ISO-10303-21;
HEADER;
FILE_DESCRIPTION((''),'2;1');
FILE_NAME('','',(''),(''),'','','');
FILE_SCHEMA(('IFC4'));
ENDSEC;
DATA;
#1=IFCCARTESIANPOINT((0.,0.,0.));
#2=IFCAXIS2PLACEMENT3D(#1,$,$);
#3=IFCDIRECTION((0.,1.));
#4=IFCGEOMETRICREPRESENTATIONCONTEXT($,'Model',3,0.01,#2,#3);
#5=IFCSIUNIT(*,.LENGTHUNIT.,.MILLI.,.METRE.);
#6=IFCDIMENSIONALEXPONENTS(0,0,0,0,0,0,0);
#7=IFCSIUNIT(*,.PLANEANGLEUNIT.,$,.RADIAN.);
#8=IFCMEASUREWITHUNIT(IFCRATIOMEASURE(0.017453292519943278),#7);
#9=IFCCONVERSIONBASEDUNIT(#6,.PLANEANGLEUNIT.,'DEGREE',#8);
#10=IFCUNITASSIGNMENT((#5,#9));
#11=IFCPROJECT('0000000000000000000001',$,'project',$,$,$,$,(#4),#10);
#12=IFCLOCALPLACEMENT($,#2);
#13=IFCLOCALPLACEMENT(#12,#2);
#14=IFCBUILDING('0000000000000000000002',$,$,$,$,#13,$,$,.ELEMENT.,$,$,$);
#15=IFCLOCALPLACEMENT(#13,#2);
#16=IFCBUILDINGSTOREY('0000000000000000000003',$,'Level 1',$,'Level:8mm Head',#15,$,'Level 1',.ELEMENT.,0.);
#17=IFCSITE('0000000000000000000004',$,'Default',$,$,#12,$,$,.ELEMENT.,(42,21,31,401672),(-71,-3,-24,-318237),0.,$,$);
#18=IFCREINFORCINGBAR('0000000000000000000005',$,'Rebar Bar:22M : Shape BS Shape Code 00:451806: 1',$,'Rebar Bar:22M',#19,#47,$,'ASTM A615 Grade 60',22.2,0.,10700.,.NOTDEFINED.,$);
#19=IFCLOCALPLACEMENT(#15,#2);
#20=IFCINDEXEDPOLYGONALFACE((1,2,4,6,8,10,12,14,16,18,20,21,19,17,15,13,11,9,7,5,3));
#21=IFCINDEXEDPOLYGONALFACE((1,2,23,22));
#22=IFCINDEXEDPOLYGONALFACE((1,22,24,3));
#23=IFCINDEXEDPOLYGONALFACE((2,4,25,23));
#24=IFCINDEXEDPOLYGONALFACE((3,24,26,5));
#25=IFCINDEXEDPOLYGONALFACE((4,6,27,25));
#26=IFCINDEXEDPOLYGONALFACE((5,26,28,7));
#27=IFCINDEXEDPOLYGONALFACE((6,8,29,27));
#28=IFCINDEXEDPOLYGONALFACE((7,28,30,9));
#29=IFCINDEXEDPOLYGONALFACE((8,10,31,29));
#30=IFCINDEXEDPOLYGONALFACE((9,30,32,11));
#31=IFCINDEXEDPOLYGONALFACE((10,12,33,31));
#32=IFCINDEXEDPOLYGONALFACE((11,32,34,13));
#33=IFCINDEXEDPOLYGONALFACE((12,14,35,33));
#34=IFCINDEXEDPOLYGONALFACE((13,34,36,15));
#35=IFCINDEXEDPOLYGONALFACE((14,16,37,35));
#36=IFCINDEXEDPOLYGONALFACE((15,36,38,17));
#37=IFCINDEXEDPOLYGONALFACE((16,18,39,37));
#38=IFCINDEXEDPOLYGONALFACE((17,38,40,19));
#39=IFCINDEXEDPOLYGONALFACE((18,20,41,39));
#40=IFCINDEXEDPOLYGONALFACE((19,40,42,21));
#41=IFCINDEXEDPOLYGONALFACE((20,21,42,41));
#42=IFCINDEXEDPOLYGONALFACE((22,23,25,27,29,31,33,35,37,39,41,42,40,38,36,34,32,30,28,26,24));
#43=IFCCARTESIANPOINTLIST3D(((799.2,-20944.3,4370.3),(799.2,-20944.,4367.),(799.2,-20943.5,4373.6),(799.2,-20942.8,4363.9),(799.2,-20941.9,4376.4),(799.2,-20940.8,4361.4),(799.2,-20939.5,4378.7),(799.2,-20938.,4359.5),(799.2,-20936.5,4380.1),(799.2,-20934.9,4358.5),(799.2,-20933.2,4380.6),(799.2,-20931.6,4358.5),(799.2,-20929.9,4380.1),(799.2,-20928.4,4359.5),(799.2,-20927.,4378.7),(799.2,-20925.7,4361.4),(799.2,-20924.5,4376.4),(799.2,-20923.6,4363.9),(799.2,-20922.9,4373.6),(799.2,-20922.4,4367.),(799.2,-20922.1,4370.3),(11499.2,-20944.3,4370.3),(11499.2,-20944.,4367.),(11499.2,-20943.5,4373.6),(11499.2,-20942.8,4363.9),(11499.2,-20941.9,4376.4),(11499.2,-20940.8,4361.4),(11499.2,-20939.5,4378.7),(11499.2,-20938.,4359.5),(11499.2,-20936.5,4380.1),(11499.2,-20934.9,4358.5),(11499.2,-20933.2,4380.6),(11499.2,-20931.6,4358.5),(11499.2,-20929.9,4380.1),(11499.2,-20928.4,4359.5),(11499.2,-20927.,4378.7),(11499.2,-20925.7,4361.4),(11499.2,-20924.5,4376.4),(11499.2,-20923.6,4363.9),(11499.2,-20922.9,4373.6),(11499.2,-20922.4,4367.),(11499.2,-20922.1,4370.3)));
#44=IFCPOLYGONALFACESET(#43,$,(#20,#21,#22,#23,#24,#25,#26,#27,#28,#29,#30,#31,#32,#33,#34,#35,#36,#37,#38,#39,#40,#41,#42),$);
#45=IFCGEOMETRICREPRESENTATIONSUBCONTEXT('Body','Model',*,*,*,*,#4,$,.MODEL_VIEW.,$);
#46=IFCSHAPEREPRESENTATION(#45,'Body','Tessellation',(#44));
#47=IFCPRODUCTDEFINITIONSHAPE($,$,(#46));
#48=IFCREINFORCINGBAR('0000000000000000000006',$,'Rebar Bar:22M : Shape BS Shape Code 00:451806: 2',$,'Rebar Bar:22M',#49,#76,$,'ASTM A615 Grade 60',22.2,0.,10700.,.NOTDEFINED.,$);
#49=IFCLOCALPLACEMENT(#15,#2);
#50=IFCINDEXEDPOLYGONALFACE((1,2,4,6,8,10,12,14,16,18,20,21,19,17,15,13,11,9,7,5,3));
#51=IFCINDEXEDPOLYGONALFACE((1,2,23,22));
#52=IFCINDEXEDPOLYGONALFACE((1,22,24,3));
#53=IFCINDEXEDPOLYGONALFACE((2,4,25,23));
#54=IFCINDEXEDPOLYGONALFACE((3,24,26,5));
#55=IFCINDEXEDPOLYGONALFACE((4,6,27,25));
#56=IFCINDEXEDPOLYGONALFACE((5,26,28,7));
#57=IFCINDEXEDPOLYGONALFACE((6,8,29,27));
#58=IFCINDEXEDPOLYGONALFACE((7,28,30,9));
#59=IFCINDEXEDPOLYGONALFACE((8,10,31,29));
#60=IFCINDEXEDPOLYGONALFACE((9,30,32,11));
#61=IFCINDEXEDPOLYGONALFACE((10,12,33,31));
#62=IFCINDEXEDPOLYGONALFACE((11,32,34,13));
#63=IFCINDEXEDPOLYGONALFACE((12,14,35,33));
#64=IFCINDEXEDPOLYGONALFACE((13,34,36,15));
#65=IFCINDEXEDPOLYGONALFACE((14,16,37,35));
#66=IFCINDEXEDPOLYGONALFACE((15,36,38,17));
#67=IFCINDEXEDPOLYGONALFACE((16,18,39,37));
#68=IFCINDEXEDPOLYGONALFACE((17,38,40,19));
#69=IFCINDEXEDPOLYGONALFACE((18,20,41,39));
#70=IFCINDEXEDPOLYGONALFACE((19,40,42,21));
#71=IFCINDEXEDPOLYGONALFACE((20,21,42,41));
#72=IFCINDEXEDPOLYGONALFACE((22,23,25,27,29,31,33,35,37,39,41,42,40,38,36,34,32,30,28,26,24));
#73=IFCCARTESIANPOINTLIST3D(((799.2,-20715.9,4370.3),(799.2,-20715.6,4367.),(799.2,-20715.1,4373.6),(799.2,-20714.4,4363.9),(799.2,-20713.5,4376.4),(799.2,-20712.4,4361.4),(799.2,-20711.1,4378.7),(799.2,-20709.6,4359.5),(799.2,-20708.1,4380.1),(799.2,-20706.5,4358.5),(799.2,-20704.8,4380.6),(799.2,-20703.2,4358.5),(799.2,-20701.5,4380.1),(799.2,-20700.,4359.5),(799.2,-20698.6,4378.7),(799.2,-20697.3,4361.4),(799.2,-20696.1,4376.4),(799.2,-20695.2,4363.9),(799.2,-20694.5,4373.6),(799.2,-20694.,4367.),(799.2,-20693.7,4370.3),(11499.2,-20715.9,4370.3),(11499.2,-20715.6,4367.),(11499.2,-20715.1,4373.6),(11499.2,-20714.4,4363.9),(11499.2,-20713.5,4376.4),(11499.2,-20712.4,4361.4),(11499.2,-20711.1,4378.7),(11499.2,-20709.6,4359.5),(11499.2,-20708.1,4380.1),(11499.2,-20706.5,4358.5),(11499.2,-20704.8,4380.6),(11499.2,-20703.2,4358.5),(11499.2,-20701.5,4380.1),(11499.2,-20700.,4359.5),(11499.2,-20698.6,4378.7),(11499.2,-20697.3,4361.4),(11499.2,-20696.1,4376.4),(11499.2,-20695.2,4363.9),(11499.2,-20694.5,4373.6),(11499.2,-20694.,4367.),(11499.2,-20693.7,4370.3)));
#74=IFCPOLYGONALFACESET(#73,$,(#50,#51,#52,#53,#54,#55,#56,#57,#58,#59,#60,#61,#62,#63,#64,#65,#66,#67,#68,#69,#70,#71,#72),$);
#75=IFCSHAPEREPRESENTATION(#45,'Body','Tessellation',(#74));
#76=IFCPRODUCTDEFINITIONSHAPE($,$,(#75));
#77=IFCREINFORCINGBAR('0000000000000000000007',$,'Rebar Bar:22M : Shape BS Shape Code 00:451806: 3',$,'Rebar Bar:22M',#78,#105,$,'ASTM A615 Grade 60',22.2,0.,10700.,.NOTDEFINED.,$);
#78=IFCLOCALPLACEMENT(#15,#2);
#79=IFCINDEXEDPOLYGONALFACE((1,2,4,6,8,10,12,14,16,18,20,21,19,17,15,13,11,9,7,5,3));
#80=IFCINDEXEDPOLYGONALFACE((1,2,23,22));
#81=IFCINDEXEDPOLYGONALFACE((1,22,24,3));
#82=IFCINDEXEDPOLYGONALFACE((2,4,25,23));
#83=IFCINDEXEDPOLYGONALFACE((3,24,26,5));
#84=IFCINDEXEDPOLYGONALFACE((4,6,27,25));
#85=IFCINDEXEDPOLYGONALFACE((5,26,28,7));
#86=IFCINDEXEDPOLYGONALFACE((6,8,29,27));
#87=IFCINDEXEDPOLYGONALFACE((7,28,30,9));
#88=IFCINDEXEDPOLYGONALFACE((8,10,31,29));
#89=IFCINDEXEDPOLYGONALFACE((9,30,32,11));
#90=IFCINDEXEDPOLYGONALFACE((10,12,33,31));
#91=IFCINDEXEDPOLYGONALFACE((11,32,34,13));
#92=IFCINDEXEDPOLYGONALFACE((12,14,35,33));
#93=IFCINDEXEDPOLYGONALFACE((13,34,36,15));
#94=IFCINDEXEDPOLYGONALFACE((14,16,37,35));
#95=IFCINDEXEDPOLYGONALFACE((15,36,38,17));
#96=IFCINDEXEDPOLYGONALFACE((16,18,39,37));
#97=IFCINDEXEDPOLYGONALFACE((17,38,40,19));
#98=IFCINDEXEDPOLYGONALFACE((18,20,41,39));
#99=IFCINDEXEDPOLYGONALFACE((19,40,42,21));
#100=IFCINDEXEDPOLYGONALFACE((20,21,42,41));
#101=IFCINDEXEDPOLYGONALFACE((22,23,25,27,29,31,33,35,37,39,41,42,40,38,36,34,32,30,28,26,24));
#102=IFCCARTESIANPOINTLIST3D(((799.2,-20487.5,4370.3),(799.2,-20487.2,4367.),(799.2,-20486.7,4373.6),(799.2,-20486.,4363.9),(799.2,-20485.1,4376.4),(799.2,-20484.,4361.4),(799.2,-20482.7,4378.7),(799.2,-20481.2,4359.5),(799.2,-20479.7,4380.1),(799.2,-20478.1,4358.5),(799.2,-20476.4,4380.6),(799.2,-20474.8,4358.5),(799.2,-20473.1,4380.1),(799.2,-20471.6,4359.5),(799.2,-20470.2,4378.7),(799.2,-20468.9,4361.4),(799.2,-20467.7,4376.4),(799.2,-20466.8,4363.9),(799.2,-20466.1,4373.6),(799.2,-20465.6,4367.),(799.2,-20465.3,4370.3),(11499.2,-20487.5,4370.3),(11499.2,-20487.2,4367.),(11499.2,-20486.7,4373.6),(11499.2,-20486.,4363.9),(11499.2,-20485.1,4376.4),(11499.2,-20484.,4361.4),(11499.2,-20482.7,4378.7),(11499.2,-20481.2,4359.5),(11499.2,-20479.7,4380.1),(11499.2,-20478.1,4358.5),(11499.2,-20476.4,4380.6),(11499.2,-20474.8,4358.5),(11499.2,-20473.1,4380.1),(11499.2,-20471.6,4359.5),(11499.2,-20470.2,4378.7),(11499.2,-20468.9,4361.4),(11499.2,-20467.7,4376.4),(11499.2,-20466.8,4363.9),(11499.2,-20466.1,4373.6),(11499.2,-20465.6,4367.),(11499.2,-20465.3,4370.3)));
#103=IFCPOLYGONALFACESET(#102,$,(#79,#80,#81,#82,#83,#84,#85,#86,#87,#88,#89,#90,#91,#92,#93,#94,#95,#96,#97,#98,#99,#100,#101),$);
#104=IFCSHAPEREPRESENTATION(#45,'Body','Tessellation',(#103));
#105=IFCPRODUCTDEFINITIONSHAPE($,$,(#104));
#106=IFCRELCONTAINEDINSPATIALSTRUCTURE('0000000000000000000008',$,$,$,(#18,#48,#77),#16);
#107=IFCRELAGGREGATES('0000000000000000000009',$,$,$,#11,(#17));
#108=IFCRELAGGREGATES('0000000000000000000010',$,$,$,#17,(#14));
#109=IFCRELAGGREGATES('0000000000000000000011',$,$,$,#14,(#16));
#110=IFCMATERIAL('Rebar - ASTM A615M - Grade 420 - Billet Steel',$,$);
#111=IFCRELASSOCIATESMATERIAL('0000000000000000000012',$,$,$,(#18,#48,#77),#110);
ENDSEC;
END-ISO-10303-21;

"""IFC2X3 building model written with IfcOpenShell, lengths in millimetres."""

from ifc_helpers import new_model, entity, si_unit, converted_unit, direction, origin, place, context, subcontext, project, spatial, material, element, save


model = new_model("IFC2X3")

# Units and contexts
model_context = context("Model", 3, precision=0.01, world=origin(), true_north=direction((0.0, 1.0)))
body_context = subcontext(model_context, "Body", "Model", "MODEL_VIEW")
ifc_project = project(units=[si_unit("LENGTHUNIT", "METRE", prefix="MILLI"), converted_unit("PLANEANGLEUNIT", "DEGREE", entity("IfcRatioMeasure", 0.017453292519943278), si_unit("PLANEANGLEUNIT", "RADIAN"), dimensions=[0, 0, 0, 0, 0, 0, 0])], contexts=[model_context])

# Site, building, storey
site_placement = place(None, origin())
site = spatial("IfcSite", under=ifc_project, at=site_placement, Name="Default", CompositionType="ELEMENT", RefLatitude=(42, 21, 31, 401672), RefLongitude=(-71, -3, -24, -318237), RefElevation=0.0)
building_placement = place(site_placement, origin())
building = spatial("IfcBuilding", under=site, at=building_placement, CompositionType="ELEMENT")
storey_placement = place(building_placement, origin())
storey = spatial("IfcBuildingStorey", under=building, at=storey_placement, Name="Level 1", ObjectType="Level:8mm Head", LongName="Level 1", CompositionType="ELEMENT", Elevation=0.0)

# Reinforcing bars
ifc_material = material(Name="Rebar - ASTM A615M - Grade 420 - Billet Steel")
reinforcing_bar_1_placement = place(storey_placement, origin())
element("IfcReinforcingBar", 1, at=reinforcing_bar_1_placement, inside=storey, material=ifc_material, Name="Rebar Bar:22M : Shape BS Shape Code 00:451806: 1", SteelGrade="ASTM A615 Grade 60", ObjectType="Rebar Bar:22M", BarLength=10700.0, BarRole="NOTDEFINED", CrossSectionArea=0.0, NominalDiameter=22.2, context=body_context, shape_type="AdvancedSweptSolid", body=[
    entity("IfcSweptDiskSolid", entity("IfcCompositeCurve", [entity("IfcCompositeCurveSegment", "CONTINUOUS", True, entity("IfcPolyline", [entity("IfcCartesianPoint", [799.2, -20933.2, 4369.5]), entity("IfcCartesianPoint", [11499.2, -20933.2, 4369.5])]))], False), 11.1, None, 0.0, 1.0),
])
reinforcing_bar_2_placement = place(storey_placement, origin())
element("IfcReinforcingBar", 2, at=reinforcing_bar_2_placement, inside=storey, material=ifc_material, Name="Rebar Bar:22M : Shape BS Shape Code 00:451806: 2", SteelGrade="ASTM A615 Grade 60", ObjectType="Rebar Bar:22M", BarLength=10700.0, BarRole="NOTDEFINED", CrossSectionArea=0.0, NominalDiameter=22.2, context=body_context, shape_type="AdvancedSweptSolid", body=[
    entity("IfcSweptDiskSolid", entity("IfcCompositeCurve", [entity("IfcCompositeCurveSegment", "CONTINUOUS", True, entity("IfcPolyline", [entity("IfcCartesianPoint", [799.2, -20704.8, 4369.5]), entity("IfcCartesianPoint", [11499.2, -20704.8, 4369.5])]))], False), 11.1, None, 0.0, 1.0),
])
reinforcing_bar_3_placement = place(storey_placement, origin())
element("IfcReinforcingBar", 3, at=reinforcing_bar_3_placement, inside=storey, material=ifc_material, Name="Rebar Bar:22M : Shape BS Shape Code 00:451806: 3", SteelGrade="ASTM A615 Grade 60", ObjectType="Rebar Bar:22M", BarLength=10700.0, BarRole="NOTDEFINED", CrossSectionArea=0.0, NominalDiameter=22.2, context=body_context, shape_type="AdvancedSweptSolid", body=[
    entity("IfcSweptDiskSolid", entity("IfcCompositeCurve", [entity("IfcCompositeCurveSegment", "CONTINUOUS", True, entity("IfcPolyline", [entity("IfcCartesianPoint", [799.2, -20476.4, 4369.5]), entity("IfcCartesianPoint", [11499.2, -20476.4, 4369.5])]))], False), 11.1, None, 0.0, 1.0),
])

save(model, "model.ifc")
